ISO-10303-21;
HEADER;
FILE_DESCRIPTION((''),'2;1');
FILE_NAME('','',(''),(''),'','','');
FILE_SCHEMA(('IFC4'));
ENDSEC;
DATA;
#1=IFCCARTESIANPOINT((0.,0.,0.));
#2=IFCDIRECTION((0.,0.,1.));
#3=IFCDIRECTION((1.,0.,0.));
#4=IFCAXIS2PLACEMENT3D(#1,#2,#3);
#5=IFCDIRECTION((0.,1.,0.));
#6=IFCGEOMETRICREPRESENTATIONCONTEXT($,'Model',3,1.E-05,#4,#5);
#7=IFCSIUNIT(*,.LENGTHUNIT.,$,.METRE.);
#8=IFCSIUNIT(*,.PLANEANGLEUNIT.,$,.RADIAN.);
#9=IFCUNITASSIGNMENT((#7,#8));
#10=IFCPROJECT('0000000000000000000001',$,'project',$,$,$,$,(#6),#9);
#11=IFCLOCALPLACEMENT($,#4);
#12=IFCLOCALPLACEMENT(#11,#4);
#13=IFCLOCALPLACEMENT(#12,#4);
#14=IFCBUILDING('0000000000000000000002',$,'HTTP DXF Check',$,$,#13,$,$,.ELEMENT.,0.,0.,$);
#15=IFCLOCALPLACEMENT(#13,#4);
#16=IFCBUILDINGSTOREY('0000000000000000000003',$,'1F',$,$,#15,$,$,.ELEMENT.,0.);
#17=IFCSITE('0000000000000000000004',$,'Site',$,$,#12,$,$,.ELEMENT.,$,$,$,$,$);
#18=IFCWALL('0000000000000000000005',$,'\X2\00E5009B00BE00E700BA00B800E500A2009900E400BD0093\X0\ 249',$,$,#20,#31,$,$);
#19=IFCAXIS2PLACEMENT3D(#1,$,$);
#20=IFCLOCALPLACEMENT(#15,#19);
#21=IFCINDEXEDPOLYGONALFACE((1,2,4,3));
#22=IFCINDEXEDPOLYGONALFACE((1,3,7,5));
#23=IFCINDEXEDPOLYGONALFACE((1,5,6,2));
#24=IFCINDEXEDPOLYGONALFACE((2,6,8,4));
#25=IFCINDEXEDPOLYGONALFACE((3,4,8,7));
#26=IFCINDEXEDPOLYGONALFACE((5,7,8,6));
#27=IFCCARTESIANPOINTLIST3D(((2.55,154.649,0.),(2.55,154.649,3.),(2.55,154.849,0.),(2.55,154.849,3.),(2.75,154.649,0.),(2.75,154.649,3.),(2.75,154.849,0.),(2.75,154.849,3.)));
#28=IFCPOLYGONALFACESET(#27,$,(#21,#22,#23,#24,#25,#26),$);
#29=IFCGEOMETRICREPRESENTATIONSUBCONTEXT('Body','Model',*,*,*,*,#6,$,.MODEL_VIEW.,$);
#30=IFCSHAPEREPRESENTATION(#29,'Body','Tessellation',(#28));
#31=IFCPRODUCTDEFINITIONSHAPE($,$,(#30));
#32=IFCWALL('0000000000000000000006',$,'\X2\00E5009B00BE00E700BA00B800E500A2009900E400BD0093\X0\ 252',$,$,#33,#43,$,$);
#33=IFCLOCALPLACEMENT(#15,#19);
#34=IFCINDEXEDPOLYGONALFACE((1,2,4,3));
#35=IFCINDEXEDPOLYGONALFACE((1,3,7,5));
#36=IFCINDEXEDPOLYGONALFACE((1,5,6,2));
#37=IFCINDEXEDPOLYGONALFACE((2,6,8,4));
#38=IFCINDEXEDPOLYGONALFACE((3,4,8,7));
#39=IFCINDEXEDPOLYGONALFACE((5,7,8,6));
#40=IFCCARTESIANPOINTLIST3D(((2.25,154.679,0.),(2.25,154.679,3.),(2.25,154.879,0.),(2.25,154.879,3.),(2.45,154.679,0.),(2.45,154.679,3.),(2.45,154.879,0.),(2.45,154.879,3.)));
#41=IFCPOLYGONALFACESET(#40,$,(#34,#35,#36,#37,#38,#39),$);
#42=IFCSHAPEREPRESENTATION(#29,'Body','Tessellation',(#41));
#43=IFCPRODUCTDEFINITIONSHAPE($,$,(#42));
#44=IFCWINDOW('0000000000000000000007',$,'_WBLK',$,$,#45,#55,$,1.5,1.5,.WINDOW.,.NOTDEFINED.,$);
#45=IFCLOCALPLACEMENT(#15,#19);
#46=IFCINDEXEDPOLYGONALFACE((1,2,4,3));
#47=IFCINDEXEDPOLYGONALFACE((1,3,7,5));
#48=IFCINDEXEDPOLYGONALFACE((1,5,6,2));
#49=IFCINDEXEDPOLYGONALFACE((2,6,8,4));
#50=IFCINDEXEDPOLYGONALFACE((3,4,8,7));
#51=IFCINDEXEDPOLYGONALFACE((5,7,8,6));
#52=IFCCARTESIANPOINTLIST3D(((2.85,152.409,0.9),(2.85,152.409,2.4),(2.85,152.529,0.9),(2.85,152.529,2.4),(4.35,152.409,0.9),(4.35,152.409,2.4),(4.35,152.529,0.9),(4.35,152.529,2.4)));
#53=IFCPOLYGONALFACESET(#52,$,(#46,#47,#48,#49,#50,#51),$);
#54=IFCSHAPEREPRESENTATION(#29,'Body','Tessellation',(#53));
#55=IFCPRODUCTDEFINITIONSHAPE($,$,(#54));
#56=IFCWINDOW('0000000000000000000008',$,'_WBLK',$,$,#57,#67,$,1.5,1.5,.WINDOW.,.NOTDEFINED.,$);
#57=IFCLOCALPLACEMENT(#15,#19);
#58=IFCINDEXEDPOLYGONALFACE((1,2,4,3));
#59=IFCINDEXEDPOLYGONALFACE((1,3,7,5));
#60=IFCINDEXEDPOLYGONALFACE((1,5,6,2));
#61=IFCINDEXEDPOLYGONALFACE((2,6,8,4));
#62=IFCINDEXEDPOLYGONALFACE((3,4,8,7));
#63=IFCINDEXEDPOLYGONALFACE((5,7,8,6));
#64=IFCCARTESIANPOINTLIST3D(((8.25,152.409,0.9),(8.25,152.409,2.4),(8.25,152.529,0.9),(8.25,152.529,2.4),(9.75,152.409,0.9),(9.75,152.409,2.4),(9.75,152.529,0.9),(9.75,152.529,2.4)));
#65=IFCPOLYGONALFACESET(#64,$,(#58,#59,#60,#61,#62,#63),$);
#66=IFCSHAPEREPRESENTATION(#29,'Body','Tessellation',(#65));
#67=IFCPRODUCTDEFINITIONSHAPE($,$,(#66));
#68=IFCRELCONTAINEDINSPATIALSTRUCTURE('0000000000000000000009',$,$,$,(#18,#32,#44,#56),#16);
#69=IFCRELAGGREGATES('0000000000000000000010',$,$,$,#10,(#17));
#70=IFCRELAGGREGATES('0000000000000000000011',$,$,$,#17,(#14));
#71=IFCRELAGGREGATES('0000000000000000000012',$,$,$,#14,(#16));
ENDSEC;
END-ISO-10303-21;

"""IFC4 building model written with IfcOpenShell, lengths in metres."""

from ifc_helpers import new_model, si_unit, direction, frame, frame_2d, origin_with_axes, place, context, subcontext, project, spatial, rectangle, extrude, element, save


model = new_model("IFC4")

# Units and contexts
model_context = context("Model", 3, precision=1e-05, world=origin_with_axes(), true_north=direction((0.0, 1.0, 0.0)))
body_context = subcontext(model_context, "Body", "Model", "MODEL_VIEW")
ifc_project = project(units=[si_unit("LENGTHUNIT", "METRE"), si_unit("PLANEANGLEUNIT", "RADIAN")], contexts=[model_context])

# Site, building, storey
placement = place(None, origin_with_axes())
site_placement = place(placement, origin_with_axes())
site = spatial("IfcSite", under=ifc_project, at=site_placement, Name="Site", CompositionType="ELEMENT")
building_placement = place(site_placement, origin_with_axes())
building = spatial("IfcBuilding", under=site, at=building_placement, Name="HTTP DXF Check", CompositionType="ELEMENT", ElevationOfRefHeight=0.0, ElevationOfTerrain=0.0)
storey_placement = place(building_placement, origin_with_axes())
storey = spatial("IfcBuildingStorey", under=building, at=storey_placement, Name="1F", CompositionType="ELEMENT", Elevation=0.0)

# Walls
for number, where, z_axis, x_axis, name in (
    (1, (2.65, 154.749, 0.0), (0.0, 0.0, 1.0), (0.0, 1.0, 0.0), "å\u009b¾çº¸å¢\u0099ä½\u0093 249"),
    (2, (2.35, 154.779, 0.0), (0.0, 0.0, 1.0), (0.0, 1.0, 0.0), "å\u009b¾çº¸å¢\u0099ä½\u0093 252"),
):
    element("IfcWall", number, at=place(storey_placement, frame(where, z_axis=z_axis, x_axis=x_axis)), inside=storey, Name=name, context=body_context, shape_type="SweptSolid", body=[
        extrude(rectangle(XDim=0.2, YDim=0.2, at=frame_2d((0.0, 0.0), x_axis=(1.0, 0.0, 0.0))), frame((0.0, 0.0, 0.0), z_axis=(0.0, 0.0, 1.0)), (0.0, 0.0, 1.0), 3.0),
    ])

# Windows
for number, where, z_axis, x_axis, name in (
    (3, (3.6, 152.469, 0.9), (0.0, 0.0, 1.0), (1.0, 0.0, 0.0), "_WBLK"),
    (4, (9.0, 152.469, 0.9), (0.0, 0.0, 1.0), (1.0, 0.0, 0.0), "_WBLK"),
):
    element("IfcWindow", number, at=place(storey_placement, frame(where, z_axis=z_axis, x_axis=x_axis)), inside=storey, Name=name, OverallHeight=1.5, OverallWidth=1.5, PartitioningType="NOTDEFINED", PredefinedType="WINDOW", context=body_context, shape_type="SweptSolid", body=[
        extrude(rectangle(XDim=1.5, YDim=0.12, at=frame_2d((0.0, 0.0), x_axis=(1.0, 0.0, 0.0))), frame((0.0, 0.0, 0.0), z_axis=(0.0, 0.0, 1.0)), (0.0, 0.0, 1.0), 1.5),
    ])

save(model, "model.ifc")
